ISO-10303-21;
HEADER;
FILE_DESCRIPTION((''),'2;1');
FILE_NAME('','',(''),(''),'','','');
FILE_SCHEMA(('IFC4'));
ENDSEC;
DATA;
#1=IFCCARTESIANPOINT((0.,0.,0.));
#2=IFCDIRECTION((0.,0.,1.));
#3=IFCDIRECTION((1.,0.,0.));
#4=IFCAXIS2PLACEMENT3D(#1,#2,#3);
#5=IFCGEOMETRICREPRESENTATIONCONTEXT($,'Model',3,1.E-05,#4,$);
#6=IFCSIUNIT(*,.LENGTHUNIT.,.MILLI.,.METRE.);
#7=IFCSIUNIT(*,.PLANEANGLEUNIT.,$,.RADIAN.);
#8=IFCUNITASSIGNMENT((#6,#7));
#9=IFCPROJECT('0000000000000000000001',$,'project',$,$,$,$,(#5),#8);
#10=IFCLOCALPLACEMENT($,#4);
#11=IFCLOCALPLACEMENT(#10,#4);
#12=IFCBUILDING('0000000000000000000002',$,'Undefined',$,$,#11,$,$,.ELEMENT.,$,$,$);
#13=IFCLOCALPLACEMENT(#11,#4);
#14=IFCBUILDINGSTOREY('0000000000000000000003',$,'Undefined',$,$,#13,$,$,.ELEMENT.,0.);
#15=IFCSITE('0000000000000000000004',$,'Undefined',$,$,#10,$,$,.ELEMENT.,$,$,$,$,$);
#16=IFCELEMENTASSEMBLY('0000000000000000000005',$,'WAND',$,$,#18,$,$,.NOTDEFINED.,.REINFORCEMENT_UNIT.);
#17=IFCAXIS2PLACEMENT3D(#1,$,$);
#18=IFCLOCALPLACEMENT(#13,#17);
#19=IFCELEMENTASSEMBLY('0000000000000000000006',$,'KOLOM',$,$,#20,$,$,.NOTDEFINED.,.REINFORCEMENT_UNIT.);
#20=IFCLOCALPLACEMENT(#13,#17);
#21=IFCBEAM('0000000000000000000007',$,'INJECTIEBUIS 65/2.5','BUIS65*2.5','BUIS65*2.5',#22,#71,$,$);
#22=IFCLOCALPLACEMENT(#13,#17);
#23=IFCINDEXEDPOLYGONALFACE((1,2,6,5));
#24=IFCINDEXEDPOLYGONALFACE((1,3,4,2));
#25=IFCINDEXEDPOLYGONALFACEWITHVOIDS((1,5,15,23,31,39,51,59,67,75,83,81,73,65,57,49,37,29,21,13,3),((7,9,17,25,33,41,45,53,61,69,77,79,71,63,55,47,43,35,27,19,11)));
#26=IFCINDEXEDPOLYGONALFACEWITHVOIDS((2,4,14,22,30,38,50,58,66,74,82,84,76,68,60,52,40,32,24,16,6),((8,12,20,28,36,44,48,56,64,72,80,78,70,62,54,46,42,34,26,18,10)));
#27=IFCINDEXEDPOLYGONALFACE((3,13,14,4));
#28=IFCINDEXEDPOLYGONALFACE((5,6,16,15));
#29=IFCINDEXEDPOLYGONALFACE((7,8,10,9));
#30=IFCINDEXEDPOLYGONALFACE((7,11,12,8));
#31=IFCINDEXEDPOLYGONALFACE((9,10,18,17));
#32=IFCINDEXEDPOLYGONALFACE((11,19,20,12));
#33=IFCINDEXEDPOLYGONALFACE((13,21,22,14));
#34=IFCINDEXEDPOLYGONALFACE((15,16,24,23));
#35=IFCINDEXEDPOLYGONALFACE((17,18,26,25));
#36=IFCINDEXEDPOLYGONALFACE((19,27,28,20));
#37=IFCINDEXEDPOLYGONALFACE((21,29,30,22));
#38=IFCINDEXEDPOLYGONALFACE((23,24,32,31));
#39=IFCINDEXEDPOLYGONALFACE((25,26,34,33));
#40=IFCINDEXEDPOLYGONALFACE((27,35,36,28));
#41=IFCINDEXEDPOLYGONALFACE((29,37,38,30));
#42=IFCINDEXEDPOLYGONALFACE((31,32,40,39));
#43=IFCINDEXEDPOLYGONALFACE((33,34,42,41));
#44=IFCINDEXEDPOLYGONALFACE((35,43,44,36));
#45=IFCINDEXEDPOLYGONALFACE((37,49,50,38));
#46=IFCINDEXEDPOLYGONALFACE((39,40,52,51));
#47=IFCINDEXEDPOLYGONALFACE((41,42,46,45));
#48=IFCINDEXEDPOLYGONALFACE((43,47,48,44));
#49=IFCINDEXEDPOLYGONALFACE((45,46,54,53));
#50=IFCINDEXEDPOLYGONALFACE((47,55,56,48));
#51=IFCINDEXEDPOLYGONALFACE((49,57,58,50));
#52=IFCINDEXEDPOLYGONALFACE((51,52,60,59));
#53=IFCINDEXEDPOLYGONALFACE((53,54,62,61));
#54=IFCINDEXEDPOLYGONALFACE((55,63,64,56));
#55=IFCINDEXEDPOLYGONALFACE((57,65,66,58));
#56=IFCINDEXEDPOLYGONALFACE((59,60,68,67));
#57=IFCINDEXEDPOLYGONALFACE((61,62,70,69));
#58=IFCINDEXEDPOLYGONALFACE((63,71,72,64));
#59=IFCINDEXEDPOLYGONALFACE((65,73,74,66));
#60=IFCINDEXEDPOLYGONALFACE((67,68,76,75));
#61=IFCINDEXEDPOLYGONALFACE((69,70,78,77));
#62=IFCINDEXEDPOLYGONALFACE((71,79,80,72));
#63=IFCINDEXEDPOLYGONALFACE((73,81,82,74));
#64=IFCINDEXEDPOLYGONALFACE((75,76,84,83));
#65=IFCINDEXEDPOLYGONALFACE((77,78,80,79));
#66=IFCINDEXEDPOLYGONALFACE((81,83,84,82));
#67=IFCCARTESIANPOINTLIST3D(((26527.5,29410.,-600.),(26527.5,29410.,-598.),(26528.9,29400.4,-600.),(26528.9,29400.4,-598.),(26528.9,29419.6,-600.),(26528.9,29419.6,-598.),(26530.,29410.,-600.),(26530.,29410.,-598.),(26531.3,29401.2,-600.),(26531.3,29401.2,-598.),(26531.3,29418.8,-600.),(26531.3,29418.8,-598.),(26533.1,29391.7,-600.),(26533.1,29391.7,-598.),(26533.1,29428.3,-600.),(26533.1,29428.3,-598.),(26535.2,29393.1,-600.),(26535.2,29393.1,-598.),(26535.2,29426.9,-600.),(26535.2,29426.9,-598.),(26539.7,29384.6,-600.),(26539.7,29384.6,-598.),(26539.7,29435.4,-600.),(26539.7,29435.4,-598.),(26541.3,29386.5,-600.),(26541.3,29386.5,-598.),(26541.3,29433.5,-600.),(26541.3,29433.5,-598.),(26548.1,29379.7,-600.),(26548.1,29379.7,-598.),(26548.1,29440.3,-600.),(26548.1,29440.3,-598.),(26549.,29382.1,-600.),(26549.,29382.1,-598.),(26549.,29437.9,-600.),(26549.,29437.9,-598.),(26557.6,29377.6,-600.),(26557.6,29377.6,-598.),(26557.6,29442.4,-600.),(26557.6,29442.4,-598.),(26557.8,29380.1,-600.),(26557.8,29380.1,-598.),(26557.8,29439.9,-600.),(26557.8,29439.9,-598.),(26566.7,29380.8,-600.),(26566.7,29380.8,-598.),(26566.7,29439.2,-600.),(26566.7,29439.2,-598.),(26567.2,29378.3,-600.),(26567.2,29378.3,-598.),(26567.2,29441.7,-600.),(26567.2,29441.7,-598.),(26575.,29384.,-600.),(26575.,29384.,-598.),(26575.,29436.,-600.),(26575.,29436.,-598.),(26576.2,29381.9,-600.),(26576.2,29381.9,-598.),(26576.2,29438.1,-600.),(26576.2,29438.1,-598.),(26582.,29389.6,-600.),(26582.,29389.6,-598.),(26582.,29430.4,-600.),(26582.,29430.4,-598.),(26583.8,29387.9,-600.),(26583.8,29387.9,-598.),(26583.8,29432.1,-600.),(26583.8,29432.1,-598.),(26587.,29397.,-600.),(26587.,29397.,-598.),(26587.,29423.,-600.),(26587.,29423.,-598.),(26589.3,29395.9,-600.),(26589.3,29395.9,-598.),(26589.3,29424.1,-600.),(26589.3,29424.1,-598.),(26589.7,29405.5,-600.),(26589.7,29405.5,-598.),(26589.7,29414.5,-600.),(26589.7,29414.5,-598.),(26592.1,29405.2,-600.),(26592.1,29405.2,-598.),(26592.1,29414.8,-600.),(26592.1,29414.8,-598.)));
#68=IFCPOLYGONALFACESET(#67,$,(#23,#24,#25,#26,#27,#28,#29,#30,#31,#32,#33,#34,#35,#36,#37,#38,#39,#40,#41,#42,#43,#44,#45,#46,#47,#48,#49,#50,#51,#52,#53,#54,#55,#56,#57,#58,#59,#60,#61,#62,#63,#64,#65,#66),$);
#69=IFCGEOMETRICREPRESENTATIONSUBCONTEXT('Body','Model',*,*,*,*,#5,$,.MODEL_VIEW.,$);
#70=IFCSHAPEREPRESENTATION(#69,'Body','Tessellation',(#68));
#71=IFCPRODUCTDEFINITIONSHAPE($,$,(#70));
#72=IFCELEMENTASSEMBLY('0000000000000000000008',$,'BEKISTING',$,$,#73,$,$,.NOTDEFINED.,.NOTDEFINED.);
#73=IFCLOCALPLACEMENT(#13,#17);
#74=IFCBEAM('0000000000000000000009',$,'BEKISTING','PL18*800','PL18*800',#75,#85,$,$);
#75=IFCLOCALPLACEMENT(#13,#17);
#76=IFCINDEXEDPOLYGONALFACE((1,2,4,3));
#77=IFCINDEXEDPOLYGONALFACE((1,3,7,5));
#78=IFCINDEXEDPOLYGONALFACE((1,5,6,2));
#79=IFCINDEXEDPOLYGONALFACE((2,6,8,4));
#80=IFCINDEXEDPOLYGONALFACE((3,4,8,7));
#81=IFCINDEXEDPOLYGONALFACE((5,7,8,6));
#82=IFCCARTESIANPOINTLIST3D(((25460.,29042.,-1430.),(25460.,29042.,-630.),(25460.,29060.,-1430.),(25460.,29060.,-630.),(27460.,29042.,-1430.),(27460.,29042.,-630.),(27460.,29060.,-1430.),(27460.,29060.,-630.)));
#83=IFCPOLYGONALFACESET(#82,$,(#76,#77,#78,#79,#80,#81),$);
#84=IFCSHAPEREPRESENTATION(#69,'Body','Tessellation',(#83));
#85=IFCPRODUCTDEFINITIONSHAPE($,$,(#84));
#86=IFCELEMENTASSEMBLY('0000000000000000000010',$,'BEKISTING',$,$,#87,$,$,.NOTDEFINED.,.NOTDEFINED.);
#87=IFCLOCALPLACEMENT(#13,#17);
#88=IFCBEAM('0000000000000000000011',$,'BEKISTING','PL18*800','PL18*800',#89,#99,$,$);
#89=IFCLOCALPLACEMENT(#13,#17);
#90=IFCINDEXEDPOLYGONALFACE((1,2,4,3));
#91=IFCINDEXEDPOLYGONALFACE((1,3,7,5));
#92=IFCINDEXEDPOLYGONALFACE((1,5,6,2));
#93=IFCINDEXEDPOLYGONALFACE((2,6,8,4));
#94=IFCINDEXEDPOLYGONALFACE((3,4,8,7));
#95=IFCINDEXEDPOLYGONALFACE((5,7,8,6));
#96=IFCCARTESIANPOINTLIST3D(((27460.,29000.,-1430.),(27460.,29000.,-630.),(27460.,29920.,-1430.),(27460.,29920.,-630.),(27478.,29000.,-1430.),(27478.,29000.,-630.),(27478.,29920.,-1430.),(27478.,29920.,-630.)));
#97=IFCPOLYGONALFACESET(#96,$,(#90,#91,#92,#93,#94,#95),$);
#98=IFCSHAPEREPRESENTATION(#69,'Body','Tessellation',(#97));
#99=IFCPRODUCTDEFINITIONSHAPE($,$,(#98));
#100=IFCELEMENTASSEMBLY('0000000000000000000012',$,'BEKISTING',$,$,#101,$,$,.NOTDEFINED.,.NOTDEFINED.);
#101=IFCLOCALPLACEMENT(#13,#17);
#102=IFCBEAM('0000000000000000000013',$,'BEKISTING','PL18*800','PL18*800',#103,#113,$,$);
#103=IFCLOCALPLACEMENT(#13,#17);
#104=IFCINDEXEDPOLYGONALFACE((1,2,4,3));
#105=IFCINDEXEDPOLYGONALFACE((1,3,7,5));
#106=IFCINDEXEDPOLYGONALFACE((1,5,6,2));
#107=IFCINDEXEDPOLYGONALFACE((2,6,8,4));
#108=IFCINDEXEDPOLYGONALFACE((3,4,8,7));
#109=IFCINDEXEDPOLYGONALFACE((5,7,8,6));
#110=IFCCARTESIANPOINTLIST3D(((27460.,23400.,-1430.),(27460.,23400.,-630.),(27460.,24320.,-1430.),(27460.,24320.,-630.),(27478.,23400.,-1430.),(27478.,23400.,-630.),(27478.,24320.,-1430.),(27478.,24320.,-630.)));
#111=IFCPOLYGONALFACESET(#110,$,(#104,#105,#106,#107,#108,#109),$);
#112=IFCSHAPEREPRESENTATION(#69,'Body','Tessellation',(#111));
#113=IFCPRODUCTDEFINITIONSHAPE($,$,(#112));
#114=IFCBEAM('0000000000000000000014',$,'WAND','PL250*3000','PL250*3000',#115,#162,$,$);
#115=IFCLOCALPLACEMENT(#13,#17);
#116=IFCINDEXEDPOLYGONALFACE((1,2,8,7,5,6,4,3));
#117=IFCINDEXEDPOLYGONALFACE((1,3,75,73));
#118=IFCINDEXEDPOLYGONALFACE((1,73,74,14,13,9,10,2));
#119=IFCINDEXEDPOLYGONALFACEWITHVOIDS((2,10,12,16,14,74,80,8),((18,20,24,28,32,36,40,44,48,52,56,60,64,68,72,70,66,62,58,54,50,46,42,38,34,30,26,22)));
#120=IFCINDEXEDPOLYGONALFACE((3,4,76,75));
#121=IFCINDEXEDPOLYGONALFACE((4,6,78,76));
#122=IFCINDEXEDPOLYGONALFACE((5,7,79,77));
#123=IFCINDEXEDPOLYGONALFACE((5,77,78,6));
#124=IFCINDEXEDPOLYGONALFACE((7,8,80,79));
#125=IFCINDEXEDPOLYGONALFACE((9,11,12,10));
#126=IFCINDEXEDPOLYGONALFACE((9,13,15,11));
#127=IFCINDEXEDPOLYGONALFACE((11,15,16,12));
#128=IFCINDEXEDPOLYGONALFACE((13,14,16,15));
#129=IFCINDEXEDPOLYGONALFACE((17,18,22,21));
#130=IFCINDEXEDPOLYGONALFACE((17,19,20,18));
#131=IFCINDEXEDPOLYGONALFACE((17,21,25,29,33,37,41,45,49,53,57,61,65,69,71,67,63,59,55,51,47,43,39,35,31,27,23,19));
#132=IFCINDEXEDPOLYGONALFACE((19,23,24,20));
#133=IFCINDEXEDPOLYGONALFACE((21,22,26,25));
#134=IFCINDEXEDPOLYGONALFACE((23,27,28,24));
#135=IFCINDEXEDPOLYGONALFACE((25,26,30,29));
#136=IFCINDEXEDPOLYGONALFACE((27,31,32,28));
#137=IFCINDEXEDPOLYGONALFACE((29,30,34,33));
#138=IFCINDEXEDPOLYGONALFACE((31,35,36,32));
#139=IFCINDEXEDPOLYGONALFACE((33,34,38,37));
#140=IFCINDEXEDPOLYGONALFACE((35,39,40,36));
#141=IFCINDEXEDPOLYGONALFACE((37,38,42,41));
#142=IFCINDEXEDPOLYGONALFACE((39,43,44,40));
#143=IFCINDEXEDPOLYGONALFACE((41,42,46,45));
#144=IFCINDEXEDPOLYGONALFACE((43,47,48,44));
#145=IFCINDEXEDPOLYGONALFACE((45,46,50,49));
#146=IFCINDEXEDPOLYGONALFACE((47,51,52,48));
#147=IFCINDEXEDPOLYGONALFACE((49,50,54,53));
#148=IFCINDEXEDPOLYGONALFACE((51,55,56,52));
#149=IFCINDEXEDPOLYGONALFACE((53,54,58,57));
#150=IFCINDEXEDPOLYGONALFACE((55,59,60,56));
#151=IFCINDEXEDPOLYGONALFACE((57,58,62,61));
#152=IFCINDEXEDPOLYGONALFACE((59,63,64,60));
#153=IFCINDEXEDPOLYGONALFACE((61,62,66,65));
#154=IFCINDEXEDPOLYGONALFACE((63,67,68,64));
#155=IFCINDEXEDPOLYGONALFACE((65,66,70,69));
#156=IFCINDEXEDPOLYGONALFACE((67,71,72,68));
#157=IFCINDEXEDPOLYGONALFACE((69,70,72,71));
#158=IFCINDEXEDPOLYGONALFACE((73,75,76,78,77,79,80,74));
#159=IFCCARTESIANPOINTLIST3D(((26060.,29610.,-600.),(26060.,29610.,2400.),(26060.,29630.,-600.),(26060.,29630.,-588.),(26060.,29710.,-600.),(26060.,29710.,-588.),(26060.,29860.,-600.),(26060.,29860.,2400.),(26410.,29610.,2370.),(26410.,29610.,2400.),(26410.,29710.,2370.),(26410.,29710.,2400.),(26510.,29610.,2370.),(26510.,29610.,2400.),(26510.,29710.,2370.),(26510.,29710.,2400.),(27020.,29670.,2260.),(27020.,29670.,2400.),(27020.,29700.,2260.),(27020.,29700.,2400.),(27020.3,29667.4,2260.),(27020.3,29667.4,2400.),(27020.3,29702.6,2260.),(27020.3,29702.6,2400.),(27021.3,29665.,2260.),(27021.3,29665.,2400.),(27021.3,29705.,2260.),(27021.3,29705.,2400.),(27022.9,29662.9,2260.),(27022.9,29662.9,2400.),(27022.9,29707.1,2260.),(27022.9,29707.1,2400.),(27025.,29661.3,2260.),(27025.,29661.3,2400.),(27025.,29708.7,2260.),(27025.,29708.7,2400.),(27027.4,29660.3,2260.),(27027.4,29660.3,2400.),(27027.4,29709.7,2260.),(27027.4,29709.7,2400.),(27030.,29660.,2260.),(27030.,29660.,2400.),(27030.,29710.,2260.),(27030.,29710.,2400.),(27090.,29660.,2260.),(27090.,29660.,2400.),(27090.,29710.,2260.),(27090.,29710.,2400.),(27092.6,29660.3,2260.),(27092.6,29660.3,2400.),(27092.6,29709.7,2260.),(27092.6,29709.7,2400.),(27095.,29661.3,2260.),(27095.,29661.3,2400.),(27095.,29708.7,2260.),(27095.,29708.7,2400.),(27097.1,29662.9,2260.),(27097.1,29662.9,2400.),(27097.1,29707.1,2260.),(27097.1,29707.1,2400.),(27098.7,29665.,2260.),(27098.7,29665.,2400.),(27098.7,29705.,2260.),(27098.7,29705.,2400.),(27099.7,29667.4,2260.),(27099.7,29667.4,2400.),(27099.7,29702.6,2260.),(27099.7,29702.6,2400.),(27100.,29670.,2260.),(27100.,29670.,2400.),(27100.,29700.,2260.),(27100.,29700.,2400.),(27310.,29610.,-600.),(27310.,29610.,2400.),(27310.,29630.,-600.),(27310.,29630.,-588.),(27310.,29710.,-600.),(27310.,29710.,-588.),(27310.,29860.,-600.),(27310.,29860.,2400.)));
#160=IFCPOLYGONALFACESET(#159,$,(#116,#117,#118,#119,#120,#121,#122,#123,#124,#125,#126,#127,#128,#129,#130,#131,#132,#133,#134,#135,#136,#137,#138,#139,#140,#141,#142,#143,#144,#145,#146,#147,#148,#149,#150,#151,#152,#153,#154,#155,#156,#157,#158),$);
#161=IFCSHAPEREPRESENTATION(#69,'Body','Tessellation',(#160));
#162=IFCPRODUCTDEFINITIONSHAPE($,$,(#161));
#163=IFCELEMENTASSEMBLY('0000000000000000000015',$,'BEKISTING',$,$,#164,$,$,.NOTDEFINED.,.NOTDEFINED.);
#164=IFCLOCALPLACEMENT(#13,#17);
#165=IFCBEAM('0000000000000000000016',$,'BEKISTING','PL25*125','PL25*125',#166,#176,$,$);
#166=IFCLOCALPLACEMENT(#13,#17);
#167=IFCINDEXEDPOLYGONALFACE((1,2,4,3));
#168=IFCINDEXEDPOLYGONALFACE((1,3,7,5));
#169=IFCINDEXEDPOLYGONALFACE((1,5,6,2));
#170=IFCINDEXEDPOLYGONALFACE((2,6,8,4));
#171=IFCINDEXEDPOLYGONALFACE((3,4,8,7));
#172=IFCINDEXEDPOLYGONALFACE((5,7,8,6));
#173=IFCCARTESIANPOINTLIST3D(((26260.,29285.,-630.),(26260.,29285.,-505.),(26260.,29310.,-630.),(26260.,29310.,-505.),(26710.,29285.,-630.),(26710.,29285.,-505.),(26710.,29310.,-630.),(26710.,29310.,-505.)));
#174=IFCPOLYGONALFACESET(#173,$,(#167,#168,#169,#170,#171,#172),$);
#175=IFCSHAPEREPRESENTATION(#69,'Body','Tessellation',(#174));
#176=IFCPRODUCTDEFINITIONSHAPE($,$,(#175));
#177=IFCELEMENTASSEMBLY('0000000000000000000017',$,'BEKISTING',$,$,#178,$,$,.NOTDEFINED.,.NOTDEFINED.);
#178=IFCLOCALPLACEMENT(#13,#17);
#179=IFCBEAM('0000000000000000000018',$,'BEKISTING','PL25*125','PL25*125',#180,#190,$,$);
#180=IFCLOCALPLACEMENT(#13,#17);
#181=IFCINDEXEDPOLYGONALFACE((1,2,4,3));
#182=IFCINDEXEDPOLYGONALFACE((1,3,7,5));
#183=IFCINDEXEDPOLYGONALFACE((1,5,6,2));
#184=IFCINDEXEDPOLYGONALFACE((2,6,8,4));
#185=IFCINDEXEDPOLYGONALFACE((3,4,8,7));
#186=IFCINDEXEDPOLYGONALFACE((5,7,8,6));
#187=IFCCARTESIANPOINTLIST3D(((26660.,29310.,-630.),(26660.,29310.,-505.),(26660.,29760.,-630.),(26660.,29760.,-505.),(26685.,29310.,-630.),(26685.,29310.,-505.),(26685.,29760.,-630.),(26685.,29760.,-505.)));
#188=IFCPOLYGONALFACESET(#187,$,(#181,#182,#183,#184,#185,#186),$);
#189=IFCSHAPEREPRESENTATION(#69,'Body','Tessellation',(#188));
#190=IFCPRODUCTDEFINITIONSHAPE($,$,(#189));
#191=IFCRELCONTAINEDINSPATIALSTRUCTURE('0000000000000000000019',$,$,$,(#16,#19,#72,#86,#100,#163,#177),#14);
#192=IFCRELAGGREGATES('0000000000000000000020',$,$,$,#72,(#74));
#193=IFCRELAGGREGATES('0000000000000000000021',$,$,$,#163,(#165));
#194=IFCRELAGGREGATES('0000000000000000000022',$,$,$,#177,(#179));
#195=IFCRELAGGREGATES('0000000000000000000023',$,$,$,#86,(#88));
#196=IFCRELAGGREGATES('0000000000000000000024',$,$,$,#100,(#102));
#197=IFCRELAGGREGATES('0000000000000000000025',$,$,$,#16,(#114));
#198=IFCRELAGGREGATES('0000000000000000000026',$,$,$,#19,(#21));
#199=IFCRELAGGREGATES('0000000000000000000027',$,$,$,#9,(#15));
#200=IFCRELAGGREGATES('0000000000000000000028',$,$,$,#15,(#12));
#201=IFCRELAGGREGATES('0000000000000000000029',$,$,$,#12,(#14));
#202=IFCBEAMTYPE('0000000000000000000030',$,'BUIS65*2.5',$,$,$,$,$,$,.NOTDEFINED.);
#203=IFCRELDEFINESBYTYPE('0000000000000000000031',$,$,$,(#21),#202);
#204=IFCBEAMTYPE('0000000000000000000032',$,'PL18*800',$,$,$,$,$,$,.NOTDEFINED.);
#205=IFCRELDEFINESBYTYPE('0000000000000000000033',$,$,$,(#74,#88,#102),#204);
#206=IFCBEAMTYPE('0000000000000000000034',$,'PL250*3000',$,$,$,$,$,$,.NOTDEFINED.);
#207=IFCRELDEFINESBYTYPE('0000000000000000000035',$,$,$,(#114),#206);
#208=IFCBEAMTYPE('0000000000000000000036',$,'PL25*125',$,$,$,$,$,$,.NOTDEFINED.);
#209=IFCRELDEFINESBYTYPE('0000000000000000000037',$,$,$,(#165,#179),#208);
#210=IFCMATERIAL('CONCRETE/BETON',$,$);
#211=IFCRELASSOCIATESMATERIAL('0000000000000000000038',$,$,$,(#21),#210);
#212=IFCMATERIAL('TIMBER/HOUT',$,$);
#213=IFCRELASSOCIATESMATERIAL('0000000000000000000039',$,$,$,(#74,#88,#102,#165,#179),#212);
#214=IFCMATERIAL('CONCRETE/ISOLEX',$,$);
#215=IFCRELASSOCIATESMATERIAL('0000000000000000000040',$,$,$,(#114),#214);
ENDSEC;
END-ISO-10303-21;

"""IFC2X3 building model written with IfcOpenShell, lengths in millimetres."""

from ifc_helpers import new_model, si_unit, frame, frame_2d, origin_with_axes, place, context, subcontext, project, spatial, polyline, circle_curve, parameter, trimmed, segment, composite_curve, rectangle, hollow_circle, outline, extrude, boolean, material, type_object, element, aggregate, save


model = new_model("IFC2X3")

# Units and contexts
model_context = context("Model", 3, precision=1e-05, world=origin_with_axes())
body_context = subcontext(model_context, "Body", "Model", "MODEL_VIEW")
ifc_project = project(units=[si_unit("LENGTHUNIT", "METRE", prefix="MILLI"), si_unit("PLANEANGLEUNIT", "RADIAN")], contexts=[model_context])

# Site, building, storey
site_placement = place(None, origin_with_axes())
site = spatial("IfcSite", under=ifc_project, at=site_placement, Name="Undefined", CompositionType="ELEMENT")
building_placement = place(site_placement, origin_with_axes())
building = spatial("IfcBuilding", under=site, at=building_placement, Name="Undefined", CompositionType="ELEMENT")
storey_placement = place(building_placement, origin_with_axes())
storey = spatial("IfcBuildingStorey", under=building, at=storey_placement, Name="Undefined", CompositionType="ELEMENT", Elevation=0.0)

# Element assembly
ifc_material_1 = material(Name="CONCRETE/BETON")
assembly_1_placement = place(storey_placement, origin_with_axes())
assembly_1 = element("IfcElementAssembly", 1, at=assembly_1_placement, inside=storey, Name="WAND", AssemblyPlace="NOTDEFINED", PredefinedType="REINFORCEMENT_UNIT")

# Shared definitions
ifc_material_2 = material(Name="CONCRETE/ISOLEX")

# Element assembly
assembly_2_placement = place(storey_placement, origin_with_axes())
assembly_2 = element("IfcElementAssembly", 2, at=assembly_2_placement, inside=storey, Name="KOLOM", AssemblyPlace="NOTDEFINED", PredefinedType="REINFORCEMENT_UNIT")

# Shared definitions
beam_type_1 = type_object("IfcBeamType", Name="BUIS65*2.5", PredefinedType="NOTDEFINED")

# Beam
beam_1_placement = place(assembly_2_placement, frame((26560.0, 29410.0, -600.0), z_axis=(0.0, 1.0, 0.0), x_axis=(0.0, 0.0, 1.0)))
beam_1 = element("IfcBeam", 3, at=beam_1_placement, type_object=beam_type_1, material=ifc_material_1, Name="INJECTIEBUIS 65/2.5", Description="BUIS65*2.5", ObjectType="BUIS65*2.5", context=body_context, shape_type="SweptSolid", body=[
    extrude(hollow_circle(Radius=32.5, WallThickness=2.5, at=frame_2d((0.0, 0.0), x_axis=(1.0, 0.0))), frame((2.0, 0.0, 0.0), z_axis=(-1.0, 0.0, 0.0), x_axis=(0.0, -1.0, 0.0)), (0.0, 0.0, 1.0), 2.0),
])

# Element assemblies, beams
assembly_3_placement = place(storey_placement, origin_with_axes())
assembly_3 = element("IfcElementAssembly", 4, at=assembly_3_placement, inside=storey, Name="BEKISTING", AssemblyPlace="NOTDEFINED", PredefinedType="NOTDEFINED")
ifc_material_3 = material(Name="TIMBER/HOUT")
beam_type_2 = type_object("IfcBeamType", Name="PL18*800", PredefinedType="NOTDEFINED")
beam_2_placement = place(assembly_3_placement, frame((27460.0, 29051.0, -1030.0), z_axis=(0.0, 0.0, -1.0), x_axis=(-1.0, 0.0, 0.0)))
beam_2 = element("IfcBeam", 5, at=beam_2_placement, type_object=beam_type_2, material=ifc_material_3, Name="BEKISTING", Description="PL18*800", ObjectType="PL18*800", context=body_context, shape_type="SweptSolid", body=[
    extrude(rectangle(XDim=18.0, YDim=800.0, at=frame_2d((0.0, 0.0), x_axis=(1.0, 0.0))), frame((2000.0, 0.0, 0.0), z_axis=(-1.0, 0.0, 0.0), x_axis=(0.0, -1.0, 0.0)), (0.0, 0.0, 1.0), 2000.0),
])
aggregate(assembly_3, [beam_2])
assembly_4_placement = place(storey_placement, origin_with_axes())
assembly_4 = element("IfcElementAssembly", 6, at=assembly_4_placement, inside=storey, Name="BEKISTING", AssemblyPlace="NOTDEFINED", PredefinedType="NOTDEFINED")
beam_3_placement = place(assembly_4_placement, frame((27469.0, 29920.0, -1030.0), z_axis=(0.0, 0.0, 1.0), x_axis=(0.0, -1.0, 0.0)))
beam_3 = element("IfcBeam", 7, at=beam_3_placement, type_object=beam_type_2, material=ifc_material_3, Name="BEKISTING", Description="PL18*800", ObjectType="PL18*800", context=body_context, shape_type="SweptSolid", body=[
    extrude(rectangle(XDim=18.0, YDim=800.0, at=frame_2d((0.0, 0.0), x_axis=(1.0, 0.0))), frame((920.0, 0.0, 0.0), z_axis=(-1.0, 0.0, 0.0), x_axis=(0.0, -1.0, 0.0)), (0.0, 0.0, 1.0), 920.0),
])
assembly_5_placement = place(storey_placement, origin_with_axes())
assembly_5 = element("IfcElementAssembly", 8, at=assembly_5_placement, inside=storey, Name="BEKISTING", AssemblyPlace="NOTDEFINED", PredefinedType="NOTDEFINED")
beam_4_placement = place(assembly_5_placement, frame((27469.0, 24320.0, -1030.0), z_axis=(0.0, 0.0, 1.0), x_axis=(0.0, -1.0, 0.0)))
beam_4 = element("IfcBeam", 9, at=beam_4_placement, type_object=beam_type_2, material=ifc_material_3, Name="BEKISTING", Description="PL18*800", ObjectType="PL18*800", context=body_context, shape_type="SweptSolid", body=[
    extrude(rectangle(XDim=18.0, YDim=800.0, at=frame_2d((0.0, 0.0), x_axis=(1.0, 0.0))), frame((920.0, 0.0, 0.0), z_axis=(-1.0, 0.0, 0.0), x_axis=(0.0, -1.0, 0.0)), (0.0, 0.0, 1.0), 920.0),
])

# Beam
beam_type_3 = type_object("IfcBeamType", Name="PL250*3000", PredefinedType="NOTDEFINED")
beam_5_placement = place(assembly_1_placement, frame((27310.0, 29735.0, 900.0), z_axis=(0.0, 0.0, 1.0), x_axis=(-1.0, 0.0, 0.0)))
beam_5 = element("IfcBeam", 10, at=beam_5_placement, type_object=beam_type_3, material=ifc_material_2, Name="WAND", Description="PL250*3000", ObjectType="PL250*3000", context=body_context, shape_type="CSG", body=[
    boolean("DIFFERENCE", boolean("DIFFERENCE", boolean("DIFFERENCE", extrude(rectangle(XDim=250.0, YDim=3000.0, at=frame_2d((0.0, 0.0), x_axis=(1.0, 0.0))), frame((1250.0, 0.0, 0.0), z_axis=(-1.0, 0.0, 0.0), x_axis=(0.0, -1.0, 0.0)), (0.0, 0.0, 1.0), 1250.0), extrude(rectangle(XDim=100.0, YDim=100.0, at=frame_2d((0.0, 0.0), x_axis=(1.0, 0.0))), frame((850.0, 75.0, 1470.0), z_axis=(0.0, 0.0, 1.0), x_axis=(-1.0, 0.0, 0.0)), (0.0, 0.0, 1.0), 30.0)), extrude(outline(composite_curve([segment(trimmed(circle_curve(frame_2d((10.0, 10.0), x_axis=(-1.0, 0.0)), 10.0), [parameter(0.0)], [parameter(1.570796)], True, "PARAMETER"), True, "CONTINUOUS"), segment(polyline([(10.0, 0.0), (40.0, 0.0)]), True, "CONTINUOUS"), segment(trimmed(circle_curve(frame_2d((40.0, 10.0), x_axis=(0.0, -1.0)), 10.0), [parameter(0.0)], [parameter(1.570796)], True, "PARAMETER"), True, "CONTINUOUS"), segment(polyline([(50.0, 10.0), (50.0, 70.0)]), True, "CONTINUOUS"), segment(trimmed(circle_curve(frame_2d((40.0, 70.0), x_axis=(1.0, 0.0)), 10.0), [parameter(0.0)], [parameter(1.570796)], True, "PARAMETER"), True, "CONTINUOUS"), segment(polyline([(40.0, 80.0), (10.0, 80.0)]), True, "CONTINUOUS"), segment(trimmed(circle_curve(frame_2d((10.0, 70.0), x_axis=(0.0, 1.0)), 10.0), [parameter(0.0)], [parameter(1.570796)], True, "PARAMETER"), True, "CONTINUOUS"), segment(polyline([(0.0, 70.0), (0.0, 10.0)]), True, "CONTINUOUS")], self_intersect=True)), frame((210.0, 75.0, 1360.0), z_axis=(0.0, 0.0, 1.0), x_axis=(0.0, -1.0, 0.0)), (0.0, 0.0, 1.0), 150.0)), extrude(rectangle(XDim=12.0, YDim=80.0, at=frame_2d((0.0, 0.0), x_axis=(1.0, 0.0))), frame((1250.0, 65.0, -1494.0), z_axis=(-1.0, 0.0, 0.0), x_axis=(0.0, 0.0, -1.0)), (0.0, 0.0, 1.0), 1250.0)),
])

# Element assemblies, beams
assembly_6_placement = place(storey_placement, origin_with_axes())
assembly_6 = element("IfcElementAssembly", 11, at=assembly_6_placement, inside=storey, Name="BEKISTING", AssemblyPlace="NOTDEFINED", PredefinedType="NOTDEFINED")
beam_type_4 = type_object("IfcBeamType", Name="PL25*125", PredefinedType="NOTDEFINED")
beam_6_placement = place(assembly_6_placement, frame((26710.0, 29297.5, -567.5), z_axis=(0.0, 0.0, -1.0), x_axis=(-1.0, 0.0, 0.0)))
beam_6 = element("IfcBeam", 12, at=beam_6_placement, type_object=beam_type_4, material=ifc_material_3, Name="BEKISTING", Description="PL25*125", ObjectType="PL25*125", context=body_context, shape_type="SweptSolid", body=[
    extrude(rectangle(XDim=25.0, YDim=125.0, at=frame_2d((0.0, 0.0), x_axis=(1.0, 0.0))), frame((450.0, 0.0, 0.0), z_axis=(-1.0, 0.0, 0.0), x_axis=(0.0, -1.0, 0.0)), (0.0, 0.0, 1.0), 450.0),
])
aggregate(assembly_6, [beam_6])
assembly_7_placement = place(storey_placement, origin_with_axes())
assembly_7 = element("IfcElementAssembly", 13, at=assembly_7_placement, inside=storey, Name="BEKISTING", AssemblyPlace="NOTDEFINED", PredefinedType="NOTDEFINED")
beam_7_placement = place(assembly_7_placement, frame((26672.5, 29310.0, -567.5), z_axis=(0.0, 0.0, -1.0), x_axis=(0.0, 1.0, 0.0)))
beam_7 = element("IfcBeam", 14, at=beam_7_placement, type_object=beam_type_4, material=ifc_material_3, Name="BEKISTING", Description="PL25*125", ObjectType="PL25*125", context=body_context, shape_type="SweptSolid", body=[
    extrude(rectangle(XDim=25.0, YDim=125.0, at=frame_2d((0.0, 0.0), x_axis=(1.0, 0.0))), frame((450.0, 0.0, 0.0), z_axis=(-1.0, 0.0, 0.0), x_axis=(0.0, -1.0, 0.0)), (0.0, 0.0, 1.0), 450.0),
])
aggregate(assembly_7, [beam_7])

aggregate(assembly_4, [beam_3])
aggregate(assembly_5, [beam_4])

aggregate(assembly_1, [beam_5])

aggregate(assembly_2, [beam_1])

save(model, "model.ifc")
